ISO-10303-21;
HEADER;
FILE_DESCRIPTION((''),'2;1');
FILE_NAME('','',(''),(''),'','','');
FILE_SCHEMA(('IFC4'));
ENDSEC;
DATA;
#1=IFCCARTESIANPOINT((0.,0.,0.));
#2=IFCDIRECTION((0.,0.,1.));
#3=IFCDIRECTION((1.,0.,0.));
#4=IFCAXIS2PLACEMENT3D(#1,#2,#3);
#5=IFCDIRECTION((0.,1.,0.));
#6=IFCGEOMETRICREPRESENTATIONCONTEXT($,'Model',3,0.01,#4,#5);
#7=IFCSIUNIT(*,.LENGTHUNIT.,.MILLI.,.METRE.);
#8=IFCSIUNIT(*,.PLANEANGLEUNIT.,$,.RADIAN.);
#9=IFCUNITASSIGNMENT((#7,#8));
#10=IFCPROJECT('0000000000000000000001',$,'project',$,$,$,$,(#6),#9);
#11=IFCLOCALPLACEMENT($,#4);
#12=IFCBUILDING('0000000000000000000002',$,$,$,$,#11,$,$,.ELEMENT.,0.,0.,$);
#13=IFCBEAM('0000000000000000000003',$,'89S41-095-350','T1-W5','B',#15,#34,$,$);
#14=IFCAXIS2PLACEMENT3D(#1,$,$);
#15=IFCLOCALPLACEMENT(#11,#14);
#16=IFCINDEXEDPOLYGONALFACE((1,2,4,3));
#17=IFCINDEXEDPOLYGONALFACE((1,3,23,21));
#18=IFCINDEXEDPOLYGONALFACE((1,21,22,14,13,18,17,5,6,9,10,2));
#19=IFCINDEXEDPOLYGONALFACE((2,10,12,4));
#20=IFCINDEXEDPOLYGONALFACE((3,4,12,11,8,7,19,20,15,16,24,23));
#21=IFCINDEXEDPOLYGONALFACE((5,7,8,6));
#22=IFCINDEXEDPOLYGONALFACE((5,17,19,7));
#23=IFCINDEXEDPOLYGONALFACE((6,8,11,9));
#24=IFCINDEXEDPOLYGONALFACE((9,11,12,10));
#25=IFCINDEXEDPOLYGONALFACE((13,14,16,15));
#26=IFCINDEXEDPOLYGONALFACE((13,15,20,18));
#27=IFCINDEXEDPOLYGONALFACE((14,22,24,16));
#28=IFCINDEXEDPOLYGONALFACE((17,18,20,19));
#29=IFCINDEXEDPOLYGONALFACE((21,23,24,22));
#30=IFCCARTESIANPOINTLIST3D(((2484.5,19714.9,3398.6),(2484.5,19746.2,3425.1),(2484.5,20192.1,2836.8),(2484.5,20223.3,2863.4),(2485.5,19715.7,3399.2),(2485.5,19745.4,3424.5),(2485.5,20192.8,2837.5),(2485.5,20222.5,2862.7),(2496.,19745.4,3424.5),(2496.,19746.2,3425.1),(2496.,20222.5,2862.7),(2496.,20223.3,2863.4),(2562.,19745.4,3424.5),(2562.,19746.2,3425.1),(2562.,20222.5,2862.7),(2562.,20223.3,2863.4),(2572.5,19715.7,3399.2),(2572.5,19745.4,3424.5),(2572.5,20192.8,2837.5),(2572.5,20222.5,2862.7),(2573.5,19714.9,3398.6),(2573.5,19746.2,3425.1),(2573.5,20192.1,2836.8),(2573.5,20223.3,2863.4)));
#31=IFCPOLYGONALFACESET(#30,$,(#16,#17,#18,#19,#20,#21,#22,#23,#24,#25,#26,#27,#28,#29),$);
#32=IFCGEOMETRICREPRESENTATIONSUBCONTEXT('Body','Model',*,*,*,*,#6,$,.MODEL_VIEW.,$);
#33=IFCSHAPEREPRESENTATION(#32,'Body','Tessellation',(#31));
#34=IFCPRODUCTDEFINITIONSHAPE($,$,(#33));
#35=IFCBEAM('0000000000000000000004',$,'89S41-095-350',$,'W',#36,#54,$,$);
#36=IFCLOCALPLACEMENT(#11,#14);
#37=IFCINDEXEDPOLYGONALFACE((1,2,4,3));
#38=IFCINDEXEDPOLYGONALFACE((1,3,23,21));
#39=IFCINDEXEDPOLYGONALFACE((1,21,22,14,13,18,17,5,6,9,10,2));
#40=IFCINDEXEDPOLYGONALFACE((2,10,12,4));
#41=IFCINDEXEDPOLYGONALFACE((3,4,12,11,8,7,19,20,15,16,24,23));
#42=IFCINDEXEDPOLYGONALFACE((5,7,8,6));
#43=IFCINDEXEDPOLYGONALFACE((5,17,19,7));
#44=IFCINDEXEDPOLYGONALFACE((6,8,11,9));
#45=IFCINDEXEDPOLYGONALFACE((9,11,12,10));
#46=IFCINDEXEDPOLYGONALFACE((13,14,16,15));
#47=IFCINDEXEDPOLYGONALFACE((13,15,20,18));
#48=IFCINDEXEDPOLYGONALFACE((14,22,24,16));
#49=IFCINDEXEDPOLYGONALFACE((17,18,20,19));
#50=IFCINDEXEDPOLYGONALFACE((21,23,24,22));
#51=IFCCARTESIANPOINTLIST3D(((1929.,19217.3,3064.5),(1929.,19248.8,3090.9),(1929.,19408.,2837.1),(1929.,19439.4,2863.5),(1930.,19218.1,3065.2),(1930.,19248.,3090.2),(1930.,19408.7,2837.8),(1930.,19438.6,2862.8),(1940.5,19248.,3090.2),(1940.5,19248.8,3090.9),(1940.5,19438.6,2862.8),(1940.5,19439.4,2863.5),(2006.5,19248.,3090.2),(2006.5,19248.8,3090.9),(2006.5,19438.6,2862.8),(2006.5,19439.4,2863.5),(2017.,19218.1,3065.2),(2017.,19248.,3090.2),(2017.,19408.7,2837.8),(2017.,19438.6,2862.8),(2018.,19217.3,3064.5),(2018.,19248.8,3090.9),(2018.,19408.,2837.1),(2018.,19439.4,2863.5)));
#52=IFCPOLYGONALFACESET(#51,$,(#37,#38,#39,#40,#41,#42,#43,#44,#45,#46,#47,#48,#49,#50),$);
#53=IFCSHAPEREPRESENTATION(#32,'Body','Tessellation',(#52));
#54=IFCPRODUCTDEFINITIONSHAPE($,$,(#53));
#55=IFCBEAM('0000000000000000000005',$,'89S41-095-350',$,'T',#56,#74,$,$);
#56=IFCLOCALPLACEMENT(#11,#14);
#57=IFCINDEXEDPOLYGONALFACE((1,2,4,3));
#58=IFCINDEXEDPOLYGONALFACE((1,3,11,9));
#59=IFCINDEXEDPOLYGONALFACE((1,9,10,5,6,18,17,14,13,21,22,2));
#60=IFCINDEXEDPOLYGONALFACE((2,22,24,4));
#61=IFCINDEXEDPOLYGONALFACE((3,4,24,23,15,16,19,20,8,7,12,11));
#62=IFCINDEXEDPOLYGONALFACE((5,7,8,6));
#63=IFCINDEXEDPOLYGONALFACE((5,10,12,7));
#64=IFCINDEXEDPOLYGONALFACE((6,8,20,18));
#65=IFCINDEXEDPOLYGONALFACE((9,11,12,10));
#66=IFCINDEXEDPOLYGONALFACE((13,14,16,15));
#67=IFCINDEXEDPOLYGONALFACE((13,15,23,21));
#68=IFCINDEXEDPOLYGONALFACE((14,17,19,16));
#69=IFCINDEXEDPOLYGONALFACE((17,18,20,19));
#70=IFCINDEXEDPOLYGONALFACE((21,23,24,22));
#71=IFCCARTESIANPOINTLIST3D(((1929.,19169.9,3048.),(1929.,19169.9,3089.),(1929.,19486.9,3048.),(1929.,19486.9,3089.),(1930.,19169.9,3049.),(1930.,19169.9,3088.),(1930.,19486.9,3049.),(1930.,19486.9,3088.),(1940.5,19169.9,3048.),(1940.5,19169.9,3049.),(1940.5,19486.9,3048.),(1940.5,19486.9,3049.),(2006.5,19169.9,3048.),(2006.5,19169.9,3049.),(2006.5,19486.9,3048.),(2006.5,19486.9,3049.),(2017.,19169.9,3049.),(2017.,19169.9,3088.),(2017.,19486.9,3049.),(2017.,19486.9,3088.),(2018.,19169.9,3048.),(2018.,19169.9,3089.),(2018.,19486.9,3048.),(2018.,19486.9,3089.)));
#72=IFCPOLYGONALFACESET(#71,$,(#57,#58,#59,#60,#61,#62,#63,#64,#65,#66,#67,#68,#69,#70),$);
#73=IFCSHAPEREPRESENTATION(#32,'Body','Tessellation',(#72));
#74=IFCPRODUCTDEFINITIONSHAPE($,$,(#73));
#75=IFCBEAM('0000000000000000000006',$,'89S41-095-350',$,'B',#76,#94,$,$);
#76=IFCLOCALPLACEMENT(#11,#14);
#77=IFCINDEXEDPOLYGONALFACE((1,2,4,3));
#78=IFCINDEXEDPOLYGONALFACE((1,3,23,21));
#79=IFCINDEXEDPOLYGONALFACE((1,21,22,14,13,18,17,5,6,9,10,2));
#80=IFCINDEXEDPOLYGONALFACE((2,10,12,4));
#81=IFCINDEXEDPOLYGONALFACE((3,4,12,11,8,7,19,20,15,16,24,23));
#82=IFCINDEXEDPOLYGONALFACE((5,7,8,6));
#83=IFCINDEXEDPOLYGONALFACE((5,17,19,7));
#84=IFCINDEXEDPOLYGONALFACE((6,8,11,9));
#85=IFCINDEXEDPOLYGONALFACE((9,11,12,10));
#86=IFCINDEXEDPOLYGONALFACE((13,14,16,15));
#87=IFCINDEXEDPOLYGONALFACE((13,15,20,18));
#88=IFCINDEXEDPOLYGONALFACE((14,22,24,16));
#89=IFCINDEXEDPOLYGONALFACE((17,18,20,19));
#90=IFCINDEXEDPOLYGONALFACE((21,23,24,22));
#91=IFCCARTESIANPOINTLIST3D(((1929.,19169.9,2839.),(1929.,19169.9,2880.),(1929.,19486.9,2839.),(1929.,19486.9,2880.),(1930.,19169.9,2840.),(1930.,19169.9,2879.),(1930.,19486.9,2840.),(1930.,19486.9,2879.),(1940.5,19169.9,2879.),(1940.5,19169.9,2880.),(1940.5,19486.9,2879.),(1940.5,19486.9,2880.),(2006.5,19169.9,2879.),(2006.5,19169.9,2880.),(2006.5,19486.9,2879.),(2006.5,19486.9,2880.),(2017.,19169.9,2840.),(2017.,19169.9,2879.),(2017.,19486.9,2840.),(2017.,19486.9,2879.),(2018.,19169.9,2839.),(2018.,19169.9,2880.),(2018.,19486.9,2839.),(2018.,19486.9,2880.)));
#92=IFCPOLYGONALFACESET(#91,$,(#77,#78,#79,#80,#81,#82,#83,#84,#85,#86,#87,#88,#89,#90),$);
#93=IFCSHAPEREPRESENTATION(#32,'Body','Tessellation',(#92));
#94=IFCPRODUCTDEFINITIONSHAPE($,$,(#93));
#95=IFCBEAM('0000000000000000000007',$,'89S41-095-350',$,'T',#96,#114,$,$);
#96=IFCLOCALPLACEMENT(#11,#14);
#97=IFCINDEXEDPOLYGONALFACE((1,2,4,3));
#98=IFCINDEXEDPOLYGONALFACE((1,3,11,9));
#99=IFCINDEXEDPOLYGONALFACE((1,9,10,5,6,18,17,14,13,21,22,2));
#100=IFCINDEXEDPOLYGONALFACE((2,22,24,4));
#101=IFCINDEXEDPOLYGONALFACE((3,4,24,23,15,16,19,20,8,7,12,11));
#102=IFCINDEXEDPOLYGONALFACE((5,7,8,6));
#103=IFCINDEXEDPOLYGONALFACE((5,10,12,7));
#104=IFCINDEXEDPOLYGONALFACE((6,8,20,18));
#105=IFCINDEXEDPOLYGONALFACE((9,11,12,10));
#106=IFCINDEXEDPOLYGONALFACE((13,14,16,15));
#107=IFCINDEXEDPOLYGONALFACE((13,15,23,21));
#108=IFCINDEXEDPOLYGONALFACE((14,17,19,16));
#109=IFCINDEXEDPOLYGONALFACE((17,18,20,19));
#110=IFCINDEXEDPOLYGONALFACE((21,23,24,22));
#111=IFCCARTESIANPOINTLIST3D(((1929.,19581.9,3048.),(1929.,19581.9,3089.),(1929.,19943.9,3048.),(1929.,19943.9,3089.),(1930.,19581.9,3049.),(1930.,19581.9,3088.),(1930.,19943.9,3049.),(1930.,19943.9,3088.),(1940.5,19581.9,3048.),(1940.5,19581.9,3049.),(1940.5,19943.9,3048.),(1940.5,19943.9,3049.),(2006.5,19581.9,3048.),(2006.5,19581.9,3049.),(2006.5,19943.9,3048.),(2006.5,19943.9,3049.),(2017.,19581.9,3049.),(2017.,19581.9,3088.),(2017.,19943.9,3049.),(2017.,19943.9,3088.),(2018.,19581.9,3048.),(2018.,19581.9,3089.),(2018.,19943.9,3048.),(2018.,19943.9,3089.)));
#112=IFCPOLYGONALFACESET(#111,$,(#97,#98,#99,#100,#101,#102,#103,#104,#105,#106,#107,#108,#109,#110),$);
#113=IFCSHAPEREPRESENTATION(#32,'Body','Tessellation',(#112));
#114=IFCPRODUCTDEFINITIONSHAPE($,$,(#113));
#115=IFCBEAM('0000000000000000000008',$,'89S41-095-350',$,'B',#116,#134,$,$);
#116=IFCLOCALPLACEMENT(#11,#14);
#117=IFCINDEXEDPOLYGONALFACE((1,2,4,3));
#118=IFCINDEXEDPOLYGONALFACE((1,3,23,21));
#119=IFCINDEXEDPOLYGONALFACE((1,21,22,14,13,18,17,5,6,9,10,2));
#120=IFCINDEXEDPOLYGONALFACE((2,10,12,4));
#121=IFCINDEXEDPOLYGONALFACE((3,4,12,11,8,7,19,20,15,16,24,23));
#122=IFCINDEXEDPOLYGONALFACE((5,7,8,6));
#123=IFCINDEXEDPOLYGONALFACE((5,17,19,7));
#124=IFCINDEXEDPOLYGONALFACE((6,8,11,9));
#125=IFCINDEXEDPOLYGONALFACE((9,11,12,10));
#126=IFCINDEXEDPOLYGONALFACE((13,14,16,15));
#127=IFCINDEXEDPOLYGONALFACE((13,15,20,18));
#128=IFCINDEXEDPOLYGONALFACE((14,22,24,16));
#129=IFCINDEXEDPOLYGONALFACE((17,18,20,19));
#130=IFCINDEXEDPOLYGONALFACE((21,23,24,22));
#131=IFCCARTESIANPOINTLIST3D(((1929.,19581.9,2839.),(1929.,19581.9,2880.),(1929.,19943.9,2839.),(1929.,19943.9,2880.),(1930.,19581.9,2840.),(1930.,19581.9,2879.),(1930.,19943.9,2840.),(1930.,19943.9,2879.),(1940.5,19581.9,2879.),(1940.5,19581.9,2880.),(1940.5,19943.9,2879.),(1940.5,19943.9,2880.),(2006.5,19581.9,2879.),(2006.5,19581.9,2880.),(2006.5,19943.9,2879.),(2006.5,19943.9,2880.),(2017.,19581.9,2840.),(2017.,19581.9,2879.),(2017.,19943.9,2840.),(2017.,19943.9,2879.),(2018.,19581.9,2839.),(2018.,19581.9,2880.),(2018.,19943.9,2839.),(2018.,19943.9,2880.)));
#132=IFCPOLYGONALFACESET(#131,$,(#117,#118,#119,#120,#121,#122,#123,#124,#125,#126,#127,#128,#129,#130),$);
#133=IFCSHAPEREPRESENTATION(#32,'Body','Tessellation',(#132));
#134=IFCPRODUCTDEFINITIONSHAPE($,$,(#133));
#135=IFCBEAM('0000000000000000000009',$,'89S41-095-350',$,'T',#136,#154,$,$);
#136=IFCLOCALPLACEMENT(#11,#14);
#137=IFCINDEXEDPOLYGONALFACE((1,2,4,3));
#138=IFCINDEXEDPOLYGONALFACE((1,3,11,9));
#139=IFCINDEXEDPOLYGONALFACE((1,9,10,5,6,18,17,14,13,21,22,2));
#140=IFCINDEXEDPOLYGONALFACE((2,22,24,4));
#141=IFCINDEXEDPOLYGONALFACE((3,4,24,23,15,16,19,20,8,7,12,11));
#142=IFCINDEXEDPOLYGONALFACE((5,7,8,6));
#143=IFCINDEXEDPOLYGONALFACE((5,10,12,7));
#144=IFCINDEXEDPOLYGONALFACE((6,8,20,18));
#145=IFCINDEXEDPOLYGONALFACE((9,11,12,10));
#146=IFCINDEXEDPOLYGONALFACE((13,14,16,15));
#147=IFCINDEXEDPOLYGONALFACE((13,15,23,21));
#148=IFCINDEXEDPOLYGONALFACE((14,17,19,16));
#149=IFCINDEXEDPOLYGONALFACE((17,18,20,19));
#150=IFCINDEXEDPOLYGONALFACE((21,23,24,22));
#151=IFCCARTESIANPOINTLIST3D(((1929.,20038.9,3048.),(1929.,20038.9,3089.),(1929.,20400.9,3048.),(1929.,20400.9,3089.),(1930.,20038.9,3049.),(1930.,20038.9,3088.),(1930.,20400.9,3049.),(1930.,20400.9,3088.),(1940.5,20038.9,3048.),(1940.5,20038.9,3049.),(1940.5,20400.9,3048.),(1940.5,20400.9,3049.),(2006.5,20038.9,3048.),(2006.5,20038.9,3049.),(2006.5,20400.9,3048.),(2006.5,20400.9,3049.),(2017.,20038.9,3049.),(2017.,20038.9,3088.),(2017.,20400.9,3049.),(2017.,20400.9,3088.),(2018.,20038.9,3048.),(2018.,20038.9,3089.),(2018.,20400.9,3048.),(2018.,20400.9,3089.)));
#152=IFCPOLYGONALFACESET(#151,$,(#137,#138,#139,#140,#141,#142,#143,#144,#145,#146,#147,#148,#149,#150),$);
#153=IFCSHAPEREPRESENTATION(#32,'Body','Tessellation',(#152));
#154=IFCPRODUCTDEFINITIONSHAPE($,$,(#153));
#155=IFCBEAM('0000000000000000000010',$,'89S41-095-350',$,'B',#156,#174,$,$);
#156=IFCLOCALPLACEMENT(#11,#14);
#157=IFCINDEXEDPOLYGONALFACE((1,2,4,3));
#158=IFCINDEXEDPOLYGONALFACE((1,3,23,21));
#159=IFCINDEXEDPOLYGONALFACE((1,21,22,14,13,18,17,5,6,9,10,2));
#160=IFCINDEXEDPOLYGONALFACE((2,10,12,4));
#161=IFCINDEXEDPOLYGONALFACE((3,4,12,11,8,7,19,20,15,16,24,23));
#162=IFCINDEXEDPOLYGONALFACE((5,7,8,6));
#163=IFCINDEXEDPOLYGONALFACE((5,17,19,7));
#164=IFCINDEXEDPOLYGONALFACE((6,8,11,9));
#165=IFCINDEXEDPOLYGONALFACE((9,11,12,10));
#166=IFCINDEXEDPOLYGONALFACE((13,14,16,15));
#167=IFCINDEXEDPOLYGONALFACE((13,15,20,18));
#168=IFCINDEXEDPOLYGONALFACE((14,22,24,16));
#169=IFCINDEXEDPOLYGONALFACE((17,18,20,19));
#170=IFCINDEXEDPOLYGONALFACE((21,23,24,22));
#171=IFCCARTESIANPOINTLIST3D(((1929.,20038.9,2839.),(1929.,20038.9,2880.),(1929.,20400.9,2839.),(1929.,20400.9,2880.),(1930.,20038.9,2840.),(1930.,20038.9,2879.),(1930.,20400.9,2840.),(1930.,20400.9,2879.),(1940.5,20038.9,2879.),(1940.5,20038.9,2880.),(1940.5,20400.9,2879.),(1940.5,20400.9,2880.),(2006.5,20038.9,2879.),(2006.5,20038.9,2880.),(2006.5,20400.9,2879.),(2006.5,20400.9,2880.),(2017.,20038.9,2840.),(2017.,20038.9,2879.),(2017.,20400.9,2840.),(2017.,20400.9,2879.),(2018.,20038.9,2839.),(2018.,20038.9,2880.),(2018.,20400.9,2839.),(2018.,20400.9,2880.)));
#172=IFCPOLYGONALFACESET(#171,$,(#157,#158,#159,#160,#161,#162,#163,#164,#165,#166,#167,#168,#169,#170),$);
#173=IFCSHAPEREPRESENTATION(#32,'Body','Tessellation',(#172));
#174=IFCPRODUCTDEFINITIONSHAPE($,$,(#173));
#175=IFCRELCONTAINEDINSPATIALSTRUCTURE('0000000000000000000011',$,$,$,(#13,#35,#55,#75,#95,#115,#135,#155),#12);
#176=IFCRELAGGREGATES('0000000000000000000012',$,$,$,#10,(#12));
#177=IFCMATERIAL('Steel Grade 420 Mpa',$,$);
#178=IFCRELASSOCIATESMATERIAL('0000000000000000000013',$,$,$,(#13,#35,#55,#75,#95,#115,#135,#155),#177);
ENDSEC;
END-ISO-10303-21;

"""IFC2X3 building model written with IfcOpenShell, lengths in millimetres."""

from ifc_helpers import new_model, si_unit, direction, frame, origin, origin_with_axes, origin_2d_with_axis, place, context, subcontext, project, spatial, c_section, extrude, source, transform, mapped, material, element, save


model = new_model("IFC2X3")

# Units and contexts
model_context = context("Model", 3, precision=0.01, world=origin_with_axes(), true_north=direction((0.0, 1.0, 0.0)))
body_context = subcontext(model_context, "Body", "Model", "MODEL_VIEW")
ifc_project = project(units=[si_unit("LENGTHUNIT", "METRE", prefix="MILLI"), si_unit("PLANEANGLEUNIT", "RADIAN")], contexts=[model_context])

# Building
building_placement = place(None, origin_with_axes())
building = spatial("IfcBuilding", under=ifc_project, at=building_placement, CompositionType="ELEMENT", ElevationOfRefHeight=0.0, ElevationOfTerrain=0.0)

# Shared definitions
ifc_material = material(Name="Steel Grade 420 Mpa")

# Beams
shared_shape_1 = source(origin(), body_context, "Body", "SweptSolid", [
    extrude(c_section(Depth=89.0, Width=41.0, WallThickness=1.0, Girth=11.5, at=origin_2d_with_axis()), origin_with_axes(), (0.0, 0.0, 1.0), 737.0),
])
beam_1_placement = place(None, frame((2529.0, 20207.7, 2850.1), z_axis=(0.0, -0.647361, 0.762183), x_axis=(0.0, 0.762183, 0.647361)))
element("IfcBeam", 1, at=beam_1_placement, inside=building, material=ifc_material, Name="89S41-095-350", Description="T1-W5", ObjectType="B", context=body_context, shape_type="MappedRepresentation", body=[
    mapped(shared_shape_1, transform((0.0, 0.0, 0.0), scale=1.0)),
])
shared_shape_2 = source(origin(), body_context, "Body", "SweptSolid", [
    extrude(c_section(Depth=89.0, Width=41.0, WallThickness=1.0, Girth=11.5, at=origin_2d_with_axis()), origin_with_axes(), (0.0, 0.0, 1.0), 296.7),
])
beam_2_placement = place(None, frame((1973.5, 19423.7, 2850.3), z_axis=(0.0, -0.642465, 0.766315), x_axis=(0.0, 0.766315, 0.642465)))
element("IfcBeam", 2, at=beam_2_placement, inside=building, material=ifc_material, Name="89S41-095-350", ObjectType="W", context=body_context, shape_type="MappedRepresentation", body=[
    mapped(shared_shape_2, transform((0.0, 0.0, 0.0), scale=1.0)),
])
shared_shape_3 = source(origin(), body_context, "Body", "SweptSolid", [
    extrude(c_section(Depth=89.0, Width=41.0, WallThickness=1.0, Girth=11.5, at=origin_2d_with_axis()), origin_with_axes(), (0.0, 0.0, 1.0), 317.0),
])
beam_3_placement = place(None, frame((1973.5, 19169.9, 3068.5), z_axis=(0.0, 1.0, 0.0), x_axis=(0.0, 0.0, -1.0)))
element("IfcBeam", 3, at=beam_3_placement, inside=building, material=ifc_material, Name="89S41-095-350", ObjectType="T", context=body_context, shape_type="MappedRepresentation", body=[
    mapped(shared_shape_3, transform((0.0, 0.0, 0.0), scale=1.0)),
])
shared_shape_4 = source(origin(), body_context, "Body", "SweptSolid", [
    extrude(c_section(Depth=89.0, Width=41.0, WallThickness=1.0, Girth=11.5, at=origin_2d_with_axis()), origin_with_axes(), (0.0, 0.0, 1.0), 317.0),
])
beam_4_placement = place(None, frame((1973.5, 19486.9, 2859.5), z_axis=(0.0, -1.0, 0.0), x_axis=(0.0, 0.0, 1.0)))
element("IfcBeam", 4, at=beam_4_placement, inside=building, material=ifc_material, Name="89S41-095-350", ObjectType="B", context=body_context, shape_type="MappedRepresentation", body=[
    mapped(shared_shape_4, transform((0.0, 0.0, 0.0), scale=1.0)),
])
shared_shape_5 = source(origin(), body_context, "Body", "SweptSolid", [
    extrude(c_section(Depth=89.0, Width=41.0, WallThickness=1.0, Girth=11.5, at=origin_2d_with_axis()), origin_with_axes(), (0.0, 0.0, 1.0), 362.0),
])
beam_5_placement = place(None, frame((1973.5, 19581.9, 3068.5), z_axis=(0.0, 1.0, 0.0), x_axis=(0.0, 0.0, -1.0)))
element("IfcBeam", 5, at=beam_5_placement, inside=building, material=ifc_material, Name="89S41-095-350", ObjectType="T", context=body_context, shape_type="MappedRepresentation", body=[
    mapped(shared_shape_5, transform((0.0, 0.0, 0.0), scale=1.0)),
])
shared_shape_6 = source(origin(), body_context, "Body", "SweptSolid", [
    extrude(c_section(Depth=89.0, Width=41.0, WallThickness=1.0, Girth=11.5, at=origin_2d_with_axis()), origin_with_axes(), (0.0, 0.0, 1.0), 362.0),
])
beam_6_placement = place(None, frame((1973.5, 19943.9, 2859.5), z_axis=(0.0, -1.0, 0.0), x_axis=(0.0, 0.0, 1.0)))
element("IfcBeam", 6, at=beam_6_placement, inside=building, material=ifc_material, Name="89S41-095-350", ObjectType="B", context=body_context, shape_type="MappedRepresentation", body=[
    mapped(shared_shape_6, transform((0.0, 0.0, 0.0), scale=1.0)),
])
shared_shape_7 = source(origin(), body_context, "Body", "SweptSolid", [
    extrude(c_section(Depth=89.0, Width=41.0, WallThickness=1.0, Girth=11.5, at=origin_2d_with_axis()), origin_with_axes(), (0.0, 0.0, 1.0), 362.0),
])
beam_7_placement = place(None, frame((1973.5, 20038.9, 3068.5), z_axis=(0.0, 1.0, 0.0), x_axis=(0.0, 0.0, -1.0)))
element("IfcBeam", 7, at=beam_7_placement, inside=building, material=ifc_material, Name="89S41-095-350", ObjectType="T", context=body_context, shape_type="MappedRepresentation", body=[
    mapped(shared_shape_7, transform((0.0, 0.0, 0.0), scale=1.0)),
])
shared_shape_8 = source(origin(), body_context, "Body", "SweptSolid", [
    extrude(c_section(Depth=89.0, Width=41.0, WallThickness=1.0, Girth=11.5, at=origin_2d_with_axis()), origin_with_axes(), (0.0, 0.0, 1.0), 362.0),
])
beam_8_placement = place(None, frame((1973.5, 20400.9, 2859.5), z_axis=(0.0, -1.0, 0.0), x_axis=(0.0, 0.0, 1.0)))
element("IfcBeam", 8, at=beam_8_placement, inside=building, material=ifc_material, Name="89S41-095-350", ObjectType="B", context=body_context, shape_type="MappedRepresentation", body=[
    mapped(shared_shape_8, transform((0.0, 0.0, 0.0), scale=1.0)),
])

save(model, "model.ifc")
